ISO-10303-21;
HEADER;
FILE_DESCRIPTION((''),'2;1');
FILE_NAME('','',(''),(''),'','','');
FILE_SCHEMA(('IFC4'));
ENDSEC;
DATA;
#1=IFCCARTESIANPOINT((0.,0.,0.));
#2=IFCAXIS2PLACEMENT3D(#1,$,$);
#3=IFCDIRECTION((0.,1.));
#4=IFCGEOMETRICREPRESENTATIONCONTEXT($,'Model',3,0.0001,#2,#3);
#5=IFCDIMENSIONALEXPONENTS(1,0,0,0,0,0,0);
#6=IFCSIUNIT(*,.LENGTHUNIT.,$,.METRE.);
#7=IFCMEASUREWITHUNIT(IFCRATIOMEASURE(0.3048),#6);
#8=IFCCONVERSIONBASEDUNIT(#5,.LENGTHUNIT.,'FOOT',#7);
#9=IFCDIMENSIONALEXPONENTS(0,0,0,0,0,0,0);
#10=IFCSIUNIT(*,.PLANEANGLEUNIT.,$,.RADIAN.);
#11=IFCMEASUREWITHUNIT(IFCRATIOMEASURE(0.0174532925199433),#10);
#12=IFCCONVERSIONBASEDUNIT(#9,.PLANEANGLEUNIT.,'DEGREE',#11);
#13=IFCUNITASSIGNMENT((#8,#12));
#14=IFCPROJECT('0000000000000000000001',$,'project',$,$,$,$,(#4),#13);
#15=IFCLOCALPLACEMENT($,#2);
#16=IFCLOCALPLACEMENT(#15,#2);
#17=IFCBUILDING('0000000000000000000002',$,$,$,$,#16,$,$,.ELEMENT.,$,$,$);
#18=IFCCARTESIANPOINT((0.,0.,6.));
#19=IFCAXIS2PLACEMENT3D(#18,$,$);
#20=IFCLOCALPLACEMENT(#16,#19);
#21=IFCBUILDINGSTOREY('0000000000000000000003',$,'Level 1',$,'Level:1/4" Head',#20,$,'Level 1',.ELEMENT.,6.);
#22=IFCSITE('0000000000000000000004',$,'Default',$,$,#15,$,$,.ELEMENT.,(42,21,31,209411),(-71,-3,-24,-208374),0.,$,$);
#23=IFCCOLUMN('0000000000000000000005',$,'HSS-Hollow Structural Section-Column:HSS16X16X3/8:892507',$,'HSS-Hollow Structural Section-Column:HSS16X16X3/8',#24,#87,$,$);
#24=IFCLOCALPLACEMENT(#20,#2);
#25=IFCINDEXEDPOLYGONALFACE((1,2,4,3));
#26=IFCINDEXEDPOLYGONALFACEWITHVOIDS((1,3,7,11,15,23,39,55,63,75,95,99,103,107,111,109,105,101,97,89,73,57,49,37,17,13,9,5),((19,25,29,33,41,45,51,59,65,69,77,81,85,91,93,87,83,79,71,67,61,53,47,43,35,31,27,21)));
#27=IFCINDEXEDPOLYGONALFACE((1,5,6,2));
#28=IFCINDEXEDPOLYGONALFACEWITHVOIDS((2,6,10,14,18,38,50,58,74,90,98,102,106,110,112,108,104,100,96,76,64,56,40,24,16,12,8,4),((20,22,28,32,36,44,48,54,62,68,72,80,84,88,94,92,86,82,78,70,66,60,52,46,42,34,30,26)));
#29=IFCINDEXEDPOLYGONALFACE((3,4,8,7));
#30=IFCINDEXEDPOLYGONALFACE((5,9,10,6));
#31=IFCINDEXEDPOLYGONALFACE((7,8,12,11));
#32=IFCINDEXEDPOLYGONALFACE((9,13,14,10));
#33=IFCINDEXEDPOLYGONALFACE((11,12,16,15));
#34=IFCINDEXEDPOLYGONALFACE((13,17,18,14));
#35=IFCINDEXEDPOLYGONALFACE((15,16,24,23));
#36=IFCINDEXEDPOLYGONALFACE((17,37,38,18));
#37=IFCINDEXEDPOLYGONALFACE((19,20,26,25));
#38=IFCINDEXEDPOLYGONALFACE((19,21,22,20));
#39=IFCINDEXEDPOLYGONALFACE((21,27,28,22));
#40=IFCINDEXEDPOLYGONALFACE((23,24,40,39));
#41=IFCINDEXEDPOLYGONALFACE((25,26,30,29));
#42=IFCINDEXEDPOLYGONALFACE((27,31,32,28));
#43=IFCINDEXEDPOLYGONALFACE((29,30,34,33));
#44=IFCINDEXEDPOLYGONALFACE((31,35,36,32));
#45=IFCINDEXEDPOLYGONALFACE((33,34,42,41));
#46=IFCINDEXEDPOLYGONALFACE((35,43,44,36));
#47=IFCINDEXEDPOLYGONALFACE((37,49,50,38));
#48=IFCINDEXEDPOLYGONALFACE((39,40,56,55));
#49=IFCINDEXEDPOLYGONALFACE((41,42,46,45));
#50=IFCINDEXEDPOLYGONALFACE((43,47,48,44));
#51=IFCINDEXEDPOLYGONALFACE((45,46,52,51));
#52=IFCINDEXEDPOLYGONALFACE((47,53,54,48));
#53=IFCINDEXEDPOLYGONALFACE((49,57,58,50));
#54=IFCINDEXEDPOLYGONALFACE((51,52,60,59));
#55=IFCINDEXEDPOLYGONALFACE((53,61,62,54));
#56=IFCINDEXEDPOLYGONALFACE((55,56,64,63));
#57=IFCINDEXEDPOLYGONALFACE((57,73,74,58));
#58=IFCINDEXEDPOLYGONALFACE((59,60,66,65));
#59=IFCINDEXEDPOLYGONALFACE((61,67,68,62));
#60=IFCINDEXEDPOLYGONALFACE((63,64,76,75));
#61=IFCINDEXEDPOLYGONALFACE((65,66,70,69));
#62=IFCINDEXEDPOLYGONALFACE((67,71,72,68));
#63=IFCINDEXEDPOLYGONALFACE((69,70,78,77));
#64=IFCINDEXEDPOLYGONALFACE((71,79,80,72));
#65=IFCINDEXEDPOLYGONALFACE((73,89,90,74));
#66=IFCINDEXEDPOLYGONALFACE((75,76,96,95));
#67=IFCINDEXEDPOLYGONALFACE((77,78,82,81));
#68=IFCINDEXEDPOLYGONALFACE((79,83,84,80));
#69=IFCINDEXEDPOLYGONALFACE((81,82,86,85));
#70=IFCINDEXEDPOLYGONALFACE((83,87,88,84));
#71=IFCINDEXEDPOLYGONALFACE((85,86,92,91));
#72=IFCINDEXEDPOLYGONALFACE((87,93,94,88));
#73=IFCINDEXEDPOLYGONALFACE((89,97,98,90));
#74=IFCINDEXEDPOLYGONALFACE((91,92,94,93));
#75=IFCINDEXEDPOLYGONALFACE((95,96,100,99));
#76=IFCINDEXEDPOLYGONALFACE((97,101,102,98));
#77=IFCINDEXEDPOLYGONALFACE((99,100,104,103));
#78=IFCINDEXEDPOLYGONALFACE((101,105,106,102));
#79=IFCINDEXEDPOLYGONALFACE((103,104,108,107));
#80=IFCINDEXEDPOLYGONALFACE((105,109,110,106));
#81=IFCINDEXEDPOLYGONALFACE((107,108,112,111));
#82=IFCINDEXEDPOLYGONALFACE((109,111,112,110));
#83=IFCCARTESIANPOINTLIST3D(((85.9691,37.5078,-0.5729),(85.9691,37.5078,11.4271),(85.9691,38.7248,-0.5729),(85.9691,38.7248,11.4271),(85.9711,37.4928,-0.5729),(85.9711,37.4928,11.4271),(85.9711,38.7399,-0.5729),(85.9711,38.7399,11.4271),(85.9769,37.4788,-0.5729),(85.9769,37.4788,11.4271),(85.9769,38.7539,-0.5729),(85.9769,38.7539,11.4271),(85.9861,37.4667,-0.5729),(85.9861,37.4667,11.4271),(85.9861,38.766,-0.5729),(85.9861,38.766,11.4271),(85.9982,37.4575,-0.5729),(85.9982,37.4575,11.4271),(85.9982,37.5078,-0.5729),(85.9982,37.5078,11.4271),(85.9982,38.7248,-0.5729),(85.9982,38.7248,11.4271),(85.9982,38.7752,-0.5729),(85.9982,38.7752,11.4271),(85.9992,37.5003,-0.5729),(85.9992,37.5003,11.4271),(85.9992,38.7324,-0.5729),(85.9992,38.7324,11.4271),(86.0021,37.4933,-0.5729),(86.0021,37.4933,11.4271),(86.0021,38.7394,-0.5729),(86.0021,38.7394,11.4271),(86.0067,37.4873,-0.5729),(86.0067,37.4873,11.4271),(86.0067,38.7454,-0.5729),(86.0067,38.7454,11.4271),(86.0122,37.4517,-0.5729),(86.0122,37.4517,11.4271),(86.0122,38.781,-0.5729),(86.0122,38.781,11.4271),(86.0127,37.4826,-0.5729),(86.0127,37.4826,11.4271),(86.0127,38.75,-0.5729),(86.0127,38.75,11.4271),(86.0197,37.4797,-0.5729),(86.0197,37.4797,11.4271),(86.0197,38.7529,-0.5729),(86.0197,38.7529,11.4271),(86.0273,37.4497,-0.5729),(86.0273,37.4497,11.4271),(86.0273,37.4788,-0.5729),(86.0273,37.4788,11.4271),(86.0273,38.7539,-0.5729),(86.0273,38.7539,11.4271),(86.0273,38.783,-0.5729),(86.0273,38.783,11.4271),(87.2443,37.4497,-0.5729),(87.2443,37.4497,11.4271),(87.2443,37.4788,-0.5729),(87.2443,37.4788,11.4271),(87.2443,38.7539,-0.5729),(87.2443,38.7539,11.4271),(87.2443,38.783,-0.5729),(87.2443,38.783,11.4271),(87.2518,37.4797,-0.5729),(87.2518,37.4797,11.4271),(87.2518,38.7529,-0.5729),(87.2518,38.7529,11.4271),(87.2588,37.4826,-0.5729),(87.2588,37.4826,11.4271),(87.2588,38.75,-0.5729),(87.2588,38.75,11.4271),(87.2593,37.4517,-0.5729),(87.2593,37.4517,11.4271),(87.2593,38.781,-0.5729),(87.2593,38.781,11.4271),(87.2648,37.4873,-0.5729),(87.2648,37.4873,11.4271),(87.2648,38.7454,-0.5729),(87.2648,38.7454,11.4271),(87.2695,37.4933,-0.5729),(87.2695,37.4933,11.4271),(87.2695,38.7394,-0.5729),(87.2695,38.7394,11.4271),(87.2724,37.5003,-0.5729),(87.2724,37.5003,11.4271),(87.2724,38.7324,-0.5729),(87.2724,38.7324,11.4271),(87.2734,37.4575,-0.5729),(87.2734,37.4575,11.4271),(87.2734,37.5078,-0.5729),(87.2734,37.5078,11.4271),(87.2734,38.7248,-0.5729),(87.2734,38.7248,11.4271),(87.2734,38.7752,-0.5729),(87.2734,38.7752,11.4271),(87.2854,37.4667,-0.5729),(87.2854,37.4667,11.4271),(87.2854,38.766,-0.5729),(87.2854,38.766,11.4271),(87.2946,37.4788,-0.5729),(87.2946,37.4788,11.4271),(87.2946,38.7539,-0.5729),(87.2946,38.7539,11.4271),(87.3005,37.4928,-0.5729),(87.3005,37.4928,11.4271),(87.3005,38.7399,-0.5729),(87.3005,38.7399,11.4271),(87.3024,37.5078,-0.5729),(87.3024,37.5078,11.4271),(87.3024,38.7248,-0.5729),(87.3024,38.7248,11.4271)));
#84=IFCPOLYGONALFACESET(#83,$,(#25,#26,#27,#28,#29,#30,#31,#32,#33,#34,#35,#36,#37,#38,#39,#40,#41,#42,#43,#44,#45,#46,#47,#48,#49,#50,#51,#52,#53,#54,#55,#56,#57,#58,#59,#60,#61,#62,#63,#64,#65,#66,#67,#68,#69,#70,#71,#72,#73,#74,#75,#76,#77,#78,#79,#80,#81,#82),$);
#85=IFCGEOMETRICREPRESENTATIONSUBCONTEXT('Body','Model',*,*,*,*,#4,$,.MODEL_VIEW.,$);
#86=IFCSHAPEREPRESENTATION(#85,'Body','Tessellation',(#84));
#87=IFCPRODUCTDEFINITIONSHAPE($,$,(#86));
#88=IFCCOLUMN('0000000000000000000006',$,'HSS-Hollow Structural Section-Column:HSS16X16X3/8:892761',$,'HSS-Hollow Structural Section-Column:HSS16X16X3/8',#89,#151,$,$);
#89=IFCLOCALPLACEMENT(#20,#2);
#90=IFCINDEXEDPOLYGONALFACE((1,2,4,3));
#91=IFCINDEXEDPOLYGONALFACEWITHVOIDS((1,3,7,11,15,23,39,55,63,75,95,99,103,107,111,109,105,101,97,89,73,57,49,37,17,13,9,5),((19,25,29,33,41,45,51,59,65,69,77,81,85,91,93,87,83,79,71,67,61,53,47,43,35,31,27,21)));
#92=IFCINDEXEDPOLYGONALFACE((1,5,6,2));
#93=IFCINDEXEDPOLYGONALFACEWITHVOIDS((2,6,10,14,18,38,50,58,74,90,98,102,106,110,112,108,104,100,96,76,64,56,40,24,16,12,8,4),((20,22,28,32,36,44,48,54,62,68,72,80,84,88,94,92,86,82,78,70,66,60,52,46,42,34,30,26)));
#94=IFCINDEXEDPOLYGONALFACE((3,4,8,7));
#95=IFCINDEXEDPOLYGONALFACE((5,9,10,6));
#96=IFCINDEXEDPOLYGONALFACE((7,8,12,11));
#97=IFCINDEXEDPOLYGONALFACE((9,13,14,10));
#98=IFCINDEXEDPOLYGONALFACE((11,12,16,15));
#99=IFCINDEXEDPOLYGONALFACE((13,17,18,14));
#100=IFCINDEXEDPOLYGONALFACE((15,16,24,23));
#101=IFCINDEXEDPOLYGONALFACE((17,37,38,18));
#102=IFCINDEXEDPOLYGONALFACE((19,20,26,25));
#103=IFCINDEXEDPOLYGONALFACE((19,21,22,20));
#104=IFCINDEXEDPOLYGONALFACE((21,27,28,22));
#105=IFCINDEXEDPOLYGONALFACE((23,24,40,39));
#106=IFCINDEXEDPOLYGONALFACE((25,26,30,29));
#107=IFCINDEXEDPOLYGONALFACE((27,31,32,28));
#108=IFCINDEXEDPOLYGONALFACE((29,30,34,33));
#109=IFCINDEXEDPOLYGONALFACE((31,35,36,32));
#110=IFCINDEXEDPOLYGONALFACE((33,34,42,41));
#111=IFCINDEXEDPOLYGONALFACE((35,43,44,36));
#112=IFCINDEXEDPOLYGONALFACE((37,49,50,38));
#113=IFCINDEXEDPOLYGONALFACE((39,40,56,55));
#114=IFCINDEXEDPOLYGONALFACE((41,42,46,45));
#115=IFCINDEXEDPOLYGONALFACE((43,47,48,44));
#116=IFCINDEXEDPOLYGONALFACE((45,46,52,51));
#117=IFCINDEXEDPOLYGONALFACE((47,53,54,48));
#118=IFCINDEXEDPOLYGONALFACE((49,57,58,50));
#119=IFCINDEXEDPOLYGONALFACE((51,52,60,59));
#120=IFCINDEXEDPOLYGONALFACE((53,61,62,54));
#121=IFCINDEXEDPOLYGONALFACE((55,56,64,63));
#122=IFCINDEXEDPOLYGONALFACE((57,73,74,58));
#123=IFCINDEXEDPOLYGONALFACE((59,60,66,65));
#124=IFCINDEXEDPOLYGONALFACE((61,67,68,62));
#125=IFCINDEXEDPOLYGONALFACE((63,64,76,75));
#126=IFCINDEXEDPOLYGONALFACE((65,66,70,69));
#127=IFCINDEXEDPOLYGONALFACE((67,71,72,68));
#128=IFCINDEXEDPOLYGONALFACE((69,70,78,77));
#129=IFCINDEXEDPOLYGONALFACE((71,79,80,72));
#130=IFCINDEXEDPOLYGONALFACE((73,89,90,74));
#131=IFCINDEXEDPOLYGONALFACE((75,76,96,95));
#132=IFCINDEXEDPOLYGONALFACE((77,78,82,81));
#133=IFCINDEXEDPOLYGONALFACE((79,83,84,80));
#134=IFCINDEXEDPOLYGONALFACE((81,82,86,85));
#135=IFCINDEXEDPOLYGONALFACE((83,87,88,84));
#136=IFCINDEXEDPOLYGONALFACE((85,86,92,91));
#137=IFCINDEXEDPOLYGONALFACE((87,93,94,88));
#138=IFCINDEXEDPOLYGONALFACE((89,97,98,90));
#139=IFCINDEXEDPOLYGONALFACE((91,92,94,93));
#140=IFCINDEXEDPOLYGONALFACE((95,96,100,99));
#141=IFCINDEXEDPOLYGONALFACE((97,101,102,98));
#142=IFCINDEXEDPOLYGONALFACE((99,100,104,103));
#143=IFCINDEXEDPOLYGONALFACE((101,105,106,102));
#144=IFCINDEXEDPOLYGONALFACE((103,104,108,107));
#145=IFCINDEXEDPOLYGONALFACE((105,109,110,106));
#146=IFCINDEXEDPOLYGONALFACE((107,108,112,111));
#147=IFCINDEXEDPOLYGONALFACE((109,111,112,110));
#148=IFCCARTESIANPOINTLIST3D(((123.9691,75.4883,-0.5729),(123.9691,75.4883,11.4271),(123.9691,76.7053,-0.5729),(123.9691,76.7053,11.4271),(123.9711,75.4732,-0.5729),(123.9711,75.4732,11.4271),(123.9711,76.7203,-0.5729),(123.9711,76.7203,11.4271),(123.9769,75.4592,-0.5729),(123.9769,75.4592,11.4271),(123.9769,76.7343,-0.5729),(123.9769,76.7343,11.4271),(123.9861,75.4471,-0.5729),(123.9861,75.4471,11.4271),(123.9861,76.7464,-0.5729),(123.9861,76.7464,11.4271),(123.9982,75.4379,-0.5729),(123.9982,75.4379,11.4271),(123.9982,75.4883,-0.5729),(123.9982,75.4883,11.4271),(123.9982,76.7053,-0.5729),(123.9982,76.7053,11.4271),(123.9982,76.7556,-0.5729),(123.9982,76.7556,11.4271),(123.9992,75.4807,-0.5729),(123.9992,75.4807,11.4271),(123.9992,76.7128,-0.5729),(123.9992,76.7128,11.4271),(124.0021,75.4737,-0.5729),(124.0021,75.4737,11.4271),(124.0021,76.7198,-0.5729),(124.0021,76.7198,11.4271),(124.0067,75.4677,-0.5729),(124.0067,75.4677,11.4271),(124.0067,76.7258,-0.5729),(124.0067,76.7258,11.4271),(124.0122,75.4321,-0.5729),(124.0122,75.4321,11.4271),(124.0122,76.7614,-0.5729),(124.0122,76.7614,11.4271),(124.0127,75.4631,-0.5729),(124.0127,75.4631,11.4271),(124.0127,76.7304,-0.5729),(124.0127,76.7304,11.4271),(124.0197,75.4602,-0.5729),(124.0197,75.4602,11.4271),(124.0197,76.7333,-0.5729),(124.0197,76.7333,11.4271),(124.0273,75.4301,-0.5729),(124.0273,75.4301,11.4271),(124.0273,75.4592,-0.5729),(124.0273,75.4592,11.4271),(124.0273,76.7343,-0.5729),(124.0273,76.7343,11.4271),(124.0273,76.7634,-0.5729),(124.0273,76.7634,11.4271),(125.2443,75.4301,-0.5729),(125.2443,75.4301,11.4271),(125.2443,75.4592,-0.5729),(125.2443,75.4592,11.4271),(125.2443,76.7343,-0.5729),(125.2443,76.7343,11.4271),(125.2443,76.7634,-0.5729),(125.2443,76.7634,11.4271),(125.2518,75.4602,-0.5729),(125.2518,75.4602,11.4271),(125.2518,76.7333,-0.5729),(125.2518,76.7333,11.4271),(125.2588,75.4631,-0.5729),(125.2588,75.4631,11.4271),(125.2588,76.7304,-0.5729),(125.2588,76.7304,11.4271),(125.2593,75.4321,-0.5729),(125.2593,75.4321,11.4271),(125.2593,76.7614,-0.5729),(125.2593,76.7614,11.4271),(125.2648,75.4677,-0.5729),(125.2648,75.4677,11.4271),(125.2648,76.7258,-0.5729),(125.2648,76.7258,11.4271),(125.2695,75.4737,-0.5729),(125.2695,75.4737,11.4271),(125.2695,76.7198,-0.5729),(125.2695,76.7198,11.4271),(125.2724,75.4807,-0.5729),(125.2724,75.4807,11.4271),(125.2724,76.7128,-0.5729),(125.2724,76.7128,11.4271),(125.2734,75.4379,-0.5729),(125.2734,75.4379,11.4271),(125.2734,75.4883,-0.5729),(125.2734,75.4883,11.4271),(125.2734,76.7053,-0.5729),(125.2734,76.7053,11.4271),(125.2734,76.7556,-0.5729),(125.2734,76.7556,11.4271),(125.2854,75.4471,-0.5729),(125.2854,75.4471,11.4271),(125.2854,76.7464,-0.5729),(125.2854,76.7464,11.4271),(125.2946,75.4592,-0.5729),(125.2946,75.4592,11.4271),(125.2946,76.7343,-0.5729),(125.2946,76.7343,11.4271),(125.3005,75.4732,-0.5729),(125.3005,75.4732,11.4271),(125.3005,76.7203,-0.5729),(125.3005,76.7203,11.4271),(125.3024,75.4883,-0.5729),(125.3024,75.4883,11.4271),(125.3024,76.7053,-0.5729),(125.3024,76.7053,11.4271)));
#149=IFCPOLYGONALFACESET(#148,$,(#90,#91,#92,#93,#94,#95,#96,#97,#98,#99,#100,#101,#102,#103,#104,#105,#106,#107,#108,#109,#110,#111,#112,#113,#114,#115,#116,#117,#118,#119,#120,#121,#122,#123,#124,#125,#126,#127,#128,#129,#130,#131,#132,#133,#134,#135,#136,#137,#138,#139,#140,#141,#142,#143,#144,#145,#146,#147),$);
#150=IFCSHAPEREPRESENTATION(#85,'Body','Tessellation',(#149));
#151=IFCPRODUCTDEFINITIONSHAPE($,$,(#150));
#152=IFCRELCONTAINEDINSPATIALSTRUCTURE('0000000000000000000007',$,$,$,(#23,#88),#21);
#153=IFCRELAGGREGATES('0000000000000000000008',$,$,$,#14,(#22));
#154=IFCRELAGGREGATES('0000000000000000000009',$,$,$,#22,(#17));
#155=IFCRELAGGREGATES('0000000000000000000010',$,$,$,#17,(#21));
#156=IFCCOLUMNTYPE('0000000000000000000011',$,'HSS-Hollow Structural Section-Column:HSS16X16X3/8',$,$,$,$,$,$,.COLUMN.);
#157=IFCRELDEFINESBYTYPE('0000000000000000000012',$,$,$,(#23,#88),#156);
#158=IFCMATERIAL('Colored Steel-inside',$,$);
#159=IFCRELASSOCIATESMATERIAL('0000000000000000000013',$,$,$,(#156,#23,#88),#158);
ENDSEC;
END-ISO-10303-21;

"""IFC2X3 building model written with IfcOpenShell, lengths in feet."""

from ifc_helpers import new_model, entity, si_unit, converted_unit, direction, frame, frame_2d, origin, place, context, subcontext, project, spatial, polyline, circle_curve, parameter, trimmed, segment, composite_curve, outline, extrude, source, transform, mapped, material, type_object, type_shapes, element, save


model = new_model("IFC2X3")

# Units and contexts
model_context = context("Model", 3, precision=0.0001, world=origin(), true_north=direction((0.0, 1.0)))
body_context = subcontext(model_context, "Body", "Model", "MODEL_VIEW")
ifc_project = project(units=[converted_unit("LENGTHUNIT", "FOOT", entity("IfcRatioMeasure", 0.3048), si_unit("LENGTHUNIT", "METRE"), dimensions=[1, 0, 0, 0, 0, 0, 0]), converted_unit("PLANEANGLEUNIT", "DEGREE", entity("IfcRatioMeasure", 0.0174532925199433), si_unit("PLANEANGLEUNIT", "RADIAN"), dimensions=[0, 0, 0, 0, 0, 0, 0])], contexts=[model_context])

# Site, building, storey
site_placement = place(None, origin())
site = spatial("IfcSite", under=ifc_project, at=site_placement, Name="Default", CompositionType="ELEMENT", RefLatitude=(42, 21, 31, 209411), RefLongitude=(-71, -3, -24, -208374), RefElevation=0.0)
building_placement = place(site_placement, origin())
building = spatial("IfcBuilding", under=site, at=building_placement, CompositionType="ELEMENT")
storey_placement = place(building_placement, frame((0.0, 0.0, 6.0)))
storey = spatial("IfcBuildingStorey", under=building, at=storey_placement, Name="Level 1", ObjectType="Level:1/4\" Head", LongName="Level 1", CompositionType="ELEMENT", Elevation=6.0)

# Columns
ifc_material_1 = material(Name="Colored Steel-inside")
column_type_1 = type_object("IfcColumnType", Name="HSS-Hollow Structural Section-Column:HSS16X16X3/8", PredefinedType="COLUMN", material=ifc_material_1)
shared_shape_1 = source(origin(), body_context, "Body", "SweptSolid", [
    extrude(outline(composite_curve([segment(polyline([(-0.6085, -0.6667), (0.6085, -0.6667)]), True, "CONTINUOUS"), segment(trimmed(circle_curve(frame_2d((0.6085, -0.6085), x_axis=(-1.0, 0.0)), 0.0582), [parameter(90.0)], [parameter(180.0)], True, "PARAMETER"), True, "CONTINUOUS"), segment(polyline([(0.6667, -0.6085), (0.6667, 0.6085)]), True, "CONTINUOUS"), segment(trimmed(circle_curve(frame_2d((0.6085, 0.6085), x_axis=(-1.0, 0.0)), 0.0582), [parameter(180.0)], [parameter(270.0)], True, "PARAMETER"), True, "CONTINUOUS"), segment(polyline([(0.6085, 0.6667), (-0.6085, 0.6667)]), True, "CONTINUOUS"), segment(trimmed(circle_curve(frame_2d((-0.6085, 0.6085), x_axis=(-1.0, 0.0)), 0.0582), [parameter(270.0)], [parameter(360.0)], True, "PARAMETER"), True, "CONTINUOUS"), segment(polyline([(-0.6667, 0.6085), (-0.6667, -0.6085)]), True, "CONTINUOUS"), segment(trimmed(circle_curve(frame_2d((-0.6085, -0.6085), x_axis=(-1.0, 0.0)), 0.0582), [parameter(360.0)], [parameter(90.0)], True, "PARAMETER"), True, "CONTINUOUS")], self_intersect=False), holes=[composite_curve([segment(trimmed(circle_curve(frame_2d((-0.6085, -0.6085), x_axis=(-1.0, 0.0)), 0.0291), [parameter(0.0)], [parameter(90.0)], True, "PARAMETER"), False, "CONTINUOUS"), segment(polyline([(-0.6376, -0.6085), (-0.6376, 0.6085)]), True, "CONTINUOUS"), segment(trimmed(circle_curve(frame_2d((-0.6085, 0.6085), x_axis=(-1.0, 0.0)), 0.0291), [parameter(270.0)], [parameter(360.0)], True, "PARAMETER"), False, "CONTINUOUS"), segment(polyline([(-0.6085, 0.6376), (0.6085, 0.6376)]), True, "CONTINUOUS"), segment(trimmed(circle_curve(frame_2d((0.6085, 0.6085), x_axis=(-1.0, 0.0)), 0.0291), [parameter(180.0)], [parameter(270.0)], True, "PARAMETER"), False, "CONTINUOUS"), segment(polyline([(0.6376, 0.6085), (0.6376, -0.6085)]), True, "CONTINUOUS"), segment(trimmed(circle_curve(frame_2d((0.6085, -0.6085), x_axis=(-1.0, 0.0)), 0.0291), [parameter(90.0)], [parameter(180.0)], True, "PARAMETER"), False, "CONTINUOUS"), segment(polyline([(0.6085, -0.6376), (-0.6085, -0.6376)]), True, "CONTINUOUS")], self_intersect=False)]), frame((0.0, 0.0, 5.4271), z_axis=(0.0, 0.0, 1.0), x_axis=(-1.0, 0.0, 0.0)), (0.0, 0.0, 1.0), 12.0),
])
type_shapes(column_type_1, [shared_shape_1])
for number, where, name in (
    (1, (86.6358, 38.1163, -6.0), "HSS-Hollow Structural Section-Column:HSS16X16X3/8:892507"),
    (2, (124.6358, 76.0968, -6.0), "HSS-Hollow Structural Section-Column:HSS16X16X3/8:892761"),
):
    element("IfcColumn", number, at=place(storey_placement, frame(where)), inside=storey, type_object=column_type_1, material=ifc_material_1, Name=name, ObjectType="HSS-Hollow Structural Section-Column:HSS16X16X3/8", context=body_context, shape_type="MappedRepresentation", body=[
        mapped(shared_shape_1, transform((0.0, 0.0, 0.0), scale=1.0)),
    ])

save(model, "model.ifc")
